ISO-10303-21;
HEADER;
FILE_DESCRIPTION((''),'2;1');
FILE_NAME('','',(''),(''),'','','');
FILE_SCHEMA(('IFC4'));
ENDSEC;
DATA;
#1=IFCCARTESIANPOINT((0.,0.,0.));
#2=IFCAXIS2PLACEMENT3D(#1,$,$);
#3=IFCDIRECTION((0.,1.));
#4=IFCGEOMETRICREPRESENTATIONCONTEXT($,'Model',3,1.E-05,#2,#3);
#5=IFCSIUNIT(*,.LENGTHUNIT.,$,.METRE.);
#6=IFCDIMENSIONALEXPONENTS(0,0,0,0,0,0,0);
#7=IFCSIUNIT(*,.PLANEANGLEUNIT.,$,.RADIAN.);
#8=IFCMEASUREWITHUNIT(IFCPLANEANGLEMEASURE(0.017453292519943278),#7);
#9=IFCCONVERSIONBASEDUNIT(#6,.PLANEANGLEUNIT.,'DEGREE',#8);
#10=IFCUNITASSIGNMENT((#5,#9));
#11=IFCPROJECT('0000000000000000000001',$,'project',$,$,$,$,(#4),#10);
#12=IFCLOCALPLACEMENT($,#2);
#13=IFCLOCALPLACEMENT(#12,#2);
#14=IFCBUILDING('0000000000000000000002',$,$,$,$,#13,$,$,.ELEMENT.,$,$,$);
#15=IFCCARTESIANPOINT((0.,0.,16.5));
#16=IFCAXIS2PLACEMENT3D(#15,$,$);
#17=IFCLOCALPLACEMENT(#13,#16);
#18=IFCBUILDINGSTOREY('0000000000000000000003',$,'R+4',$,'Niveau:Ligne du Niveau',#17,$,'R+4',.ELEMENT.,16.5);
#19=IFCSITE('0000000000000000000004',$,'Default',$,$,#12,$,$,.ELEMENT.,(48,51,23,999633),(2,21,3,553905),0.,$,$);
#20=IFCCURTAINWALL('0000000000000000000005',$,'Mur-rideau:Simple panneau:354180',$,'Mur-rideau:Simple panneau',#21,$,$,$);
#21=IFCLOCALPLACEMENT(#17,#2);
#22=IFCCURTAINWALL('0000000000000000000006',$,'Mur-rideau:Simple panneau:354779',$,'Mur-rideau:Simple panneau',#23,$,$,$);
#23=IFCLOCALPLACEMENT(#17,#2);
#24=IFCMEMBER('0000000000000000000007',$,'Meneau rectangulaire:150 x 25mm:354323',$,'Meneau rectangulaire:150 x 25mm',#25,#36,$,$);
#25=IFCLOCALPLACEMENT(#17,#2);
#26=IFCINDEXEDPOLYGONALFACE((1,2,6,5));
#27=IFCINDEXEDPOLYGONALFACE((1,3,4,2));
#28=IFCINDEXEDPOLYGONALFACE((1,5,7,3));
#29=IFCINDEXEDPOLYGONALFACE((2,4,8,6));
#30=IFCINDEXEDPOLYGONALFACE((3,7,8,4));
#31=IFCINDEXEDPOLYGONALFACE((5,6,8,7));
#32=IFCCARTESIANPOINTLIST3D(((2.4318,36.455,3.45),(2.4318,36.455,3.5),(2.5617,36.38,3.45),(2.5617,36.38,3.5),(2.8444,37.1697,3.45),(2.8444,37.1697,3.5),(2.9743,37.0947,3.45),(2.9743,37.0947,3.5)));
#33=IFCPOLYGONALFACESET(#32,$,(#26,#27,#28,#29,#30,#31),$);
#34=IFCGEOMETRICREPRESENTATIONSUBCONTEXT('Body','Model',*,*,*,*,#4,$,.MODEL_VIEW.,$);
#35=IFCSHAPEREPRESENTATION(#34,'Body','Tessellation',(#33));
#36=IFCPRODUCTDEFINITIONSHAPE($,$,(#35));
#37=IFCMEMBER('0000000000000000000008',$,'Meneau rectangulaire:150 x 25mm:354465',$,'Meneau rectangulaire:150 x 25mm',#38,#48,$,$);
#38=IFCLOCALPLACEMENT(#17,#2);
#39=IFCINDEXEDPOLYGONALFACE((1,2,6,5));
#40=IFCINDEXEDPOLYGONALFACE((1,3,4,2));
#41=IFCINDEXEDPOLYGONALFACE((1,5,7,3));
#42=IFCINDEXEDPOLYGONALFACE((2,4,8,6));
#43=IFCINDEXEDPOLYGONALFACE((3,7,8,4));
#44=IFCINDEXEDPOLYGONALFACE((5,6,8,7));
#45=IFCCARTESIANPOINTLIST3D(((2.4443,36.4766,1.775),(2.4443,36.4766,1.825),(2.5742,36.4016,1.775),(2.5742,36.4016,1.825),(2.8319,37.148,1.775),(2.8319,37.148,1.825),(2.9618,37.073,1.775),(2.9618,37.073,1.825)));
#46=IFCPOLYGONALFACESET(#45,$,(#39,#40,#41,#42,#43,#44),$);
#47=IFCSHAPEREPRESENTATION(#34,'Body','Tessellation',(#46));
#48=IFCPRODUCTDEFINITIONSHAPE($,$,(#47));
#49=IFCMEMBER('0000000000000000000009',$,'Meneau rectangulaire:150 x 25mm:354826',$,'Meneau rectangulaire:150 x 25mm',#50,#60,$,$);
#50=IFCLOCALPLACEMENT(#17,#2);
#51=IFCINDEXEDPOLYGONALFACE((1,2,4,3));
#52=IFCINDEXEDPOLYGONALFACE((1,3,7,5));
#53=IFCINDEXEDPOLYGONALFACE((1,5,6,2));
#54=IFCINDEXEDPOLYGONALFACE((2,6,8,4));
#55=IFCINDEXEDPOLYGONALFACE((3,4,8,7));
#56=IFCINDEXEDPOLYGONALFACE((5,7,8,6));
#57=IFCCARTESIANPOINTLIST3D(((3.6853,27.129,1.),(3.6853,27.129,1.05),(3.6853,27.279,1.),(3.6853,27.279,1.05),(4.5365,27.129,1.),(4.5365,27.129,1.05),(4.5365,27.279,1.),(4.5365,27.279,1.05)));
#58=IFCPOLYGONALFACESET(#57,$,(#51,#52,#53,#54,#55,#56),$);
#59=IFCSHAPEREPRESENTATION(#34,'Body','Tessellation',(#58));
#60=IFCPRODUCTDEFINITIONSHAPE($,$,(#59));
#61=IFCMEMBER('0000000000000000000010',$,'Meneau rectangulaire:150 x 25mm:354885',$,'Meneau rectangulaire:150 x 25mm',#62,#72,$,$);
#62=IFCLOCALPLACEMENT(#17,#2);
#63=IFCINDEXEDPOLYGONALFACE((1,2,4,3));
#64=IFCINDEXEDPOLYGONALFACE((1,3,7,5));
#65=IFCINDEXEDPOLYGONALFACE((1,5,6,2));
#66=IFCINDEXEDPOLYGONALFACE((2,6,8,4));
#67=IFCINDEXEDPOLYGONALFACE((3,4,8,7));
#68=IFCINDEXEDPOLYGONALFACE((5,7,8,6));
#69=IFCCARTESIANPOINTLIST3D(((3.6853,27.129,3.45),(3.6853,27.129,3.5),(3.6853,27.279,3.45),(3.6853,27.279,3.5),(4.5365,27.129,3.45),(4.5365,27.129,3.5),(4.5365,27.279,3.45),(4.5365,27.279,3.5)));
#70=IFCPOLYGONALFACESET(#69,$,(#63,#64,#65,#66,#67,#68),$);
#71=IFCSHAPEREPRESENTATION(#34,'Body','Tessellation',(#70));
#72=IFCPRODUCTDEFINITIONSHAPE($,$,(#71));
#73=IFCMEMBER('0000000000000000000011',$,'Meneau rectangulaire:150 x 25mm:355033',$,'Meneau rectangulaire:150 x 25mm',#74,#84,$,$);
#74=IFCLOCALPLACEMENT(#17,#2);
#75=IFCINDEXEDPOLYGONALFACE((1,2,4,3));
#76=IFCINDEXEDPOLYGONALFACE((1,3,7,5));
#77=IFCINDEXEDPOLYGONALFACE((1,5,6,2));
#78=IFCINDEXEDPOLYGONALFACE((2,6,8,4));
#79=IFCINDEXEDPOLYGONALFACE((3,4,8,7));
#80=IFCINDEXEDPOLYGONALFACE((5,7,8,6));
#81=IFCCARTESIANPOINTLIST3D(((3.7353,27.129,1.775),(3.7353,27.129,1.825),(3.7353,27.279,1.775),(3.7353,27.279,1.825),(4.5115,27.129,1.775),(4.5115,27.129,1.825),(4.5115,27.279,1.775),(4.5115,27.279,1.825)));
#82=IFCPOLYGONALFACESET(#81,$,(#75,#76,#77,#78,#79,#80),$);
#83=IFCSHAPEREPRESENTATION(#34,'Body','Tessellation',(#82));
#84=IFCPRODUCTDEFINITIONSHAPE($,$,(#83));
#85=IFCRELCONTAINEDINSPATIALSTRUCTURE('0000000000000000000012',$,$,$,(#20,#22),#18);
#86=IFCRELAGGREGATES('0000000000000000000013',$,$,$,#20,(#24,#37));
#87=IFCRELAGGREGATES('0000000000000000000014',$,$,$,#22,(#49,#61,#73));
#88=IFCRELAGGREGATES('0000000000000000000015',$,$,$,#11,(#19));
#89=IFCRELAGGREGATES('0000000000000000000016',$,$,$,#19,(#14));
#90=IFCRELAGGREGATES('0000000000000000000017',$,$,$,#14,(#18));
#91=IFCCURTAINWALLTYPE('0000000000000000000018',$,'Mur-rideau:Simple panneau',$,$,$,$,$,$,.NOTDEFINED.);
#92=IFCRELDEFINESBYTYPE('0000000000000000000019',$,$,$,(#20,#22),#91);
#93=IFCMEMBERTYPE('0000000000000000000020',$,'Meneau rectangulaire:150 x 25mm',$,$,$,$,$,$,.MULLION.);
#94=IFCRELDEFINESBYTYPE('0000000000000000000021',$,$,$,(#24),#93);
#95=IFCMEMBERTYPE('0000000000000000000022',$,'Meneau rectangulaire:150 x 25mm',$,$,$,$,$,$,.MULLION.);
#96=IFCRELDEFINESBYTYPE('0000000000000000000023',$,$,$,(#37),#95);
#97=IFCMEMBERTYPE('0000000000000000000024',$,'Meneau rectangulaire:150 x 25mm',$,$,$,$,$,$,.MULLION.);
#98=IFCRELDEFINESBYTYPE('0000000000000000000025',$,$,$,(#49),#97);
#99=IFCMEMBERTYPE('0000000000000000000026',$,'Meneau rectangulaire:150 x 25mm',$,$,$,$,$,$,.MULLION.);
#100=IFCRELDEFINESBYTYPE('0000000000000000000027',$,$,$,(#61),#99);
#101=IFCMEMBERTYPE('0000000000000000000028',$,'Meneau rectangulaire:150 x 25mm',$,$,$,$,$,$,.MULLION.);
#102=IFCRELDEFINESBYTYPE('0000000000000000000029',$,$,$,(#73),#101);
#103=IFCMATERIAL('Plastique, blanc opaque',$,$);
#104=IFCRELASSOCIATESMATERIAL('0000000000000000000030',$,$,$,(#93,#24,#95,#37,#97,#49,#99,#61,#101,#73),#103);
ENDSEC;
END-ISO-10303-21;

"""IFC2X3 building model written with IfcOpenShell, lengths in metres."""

from ifc_helpers import new_model, entity, si_unit, converted_unit, direction, frame, origin, origin_2d_with_axis, place, context, subcontext, project, spatial, rectangle, extrude, source, transform, mapped, material, type_object, type_shapes, element, aggregate, save


model = new_model("IFC2X3")

# Units and contexts
model_context = context("Model", 3, precision=1e-05, world=origin(), true_north=direction((0.0, 1.0)))
body_context = subcontext(model_context, "Body", "Model", "MODEL_VIEW")
ifc_project = project(units=[si_unit("LENGTHUNIT", "METRE"), converted_unit("PLANEANGLEUNIT", "DEGREE", entity("IfcPlaneAngleMeasure", 0.017453292519943278), si_unit("PLANEANGLEUNIT", "RADIAN"), dimensions=[0, 0, 0, 0, 0, 0, 0])], contexts=[model_context])

# Site, building, storey
site_placement = place(None, origin())
site = spatial("IfcSite", under=ifc_project, at=site_placement, Name="Default", CompositionType="ELEMENT", RefLatitude=(48, 51, 23, 999633), RefLongitude=(2, 21, 3, 553905), RefElevation=0.0)
building_placement = place(site_placement, origin())
building = spatial("IfcBuilding", under=site, at=building_placement, CompositionType="ELEMENT")
storey_placement = place(building_placement, frame((0.0, 0.0, 16.5)))
storey = spatial("IfcBuildingStorey", under=building, at=storey_placement, Name="R+4", ObjectType="Niveau:Ligne du Niveau", LongName="R+4", CompositionType="ELEMENT", Elevation=16.5)

# Curtain walls
curtain_wall_type = type_object("IfcCurtainWallType", Name="Mur-rideau:Simple panneau", PredefinedType="NOTDEFINED")
curtain_wall_1_placement = place(storey_placement, frame((0.0, 0.0, -16.5)))
curtain_wall_1 = element("IfcCurtainWall", 1, at=curtain_wall_1_placement, inside=storey, type_object=curtain_wall_type, Name="Mur-rideau:Simple panneau:354180", ObjectType="Mur-rideau:Simple panneau")
ifc_material_1 = material(Name="Plastique, blanc opaque")
curtain_wall_2_placement = place(storey_placement, frame((0.0, 0.0, -16.5)))
curtain_wall_2 = element("IfcCurtainWall", 2, at=curtain_wall_2_placement, inside=storey, type_object=curtain_wall_type, Name="Mur-rideau:Simple panneau:354779", ObjectType="Mur-rideau:Simple panneau")

# Members
member_type_1 = type_object("IfcMemberType", Name="Meneau rectangulaire:150 x 25mm", PredefinedType="MULLION", material=ifc_material_1)
shared_shape_1 = source(origin(), body_context, "Body", "SweptSolid", [
    extrude(rectangle(XDim=0.05, YDim=0.15, at=origin_2d_with_axis()), frame((-0.025, 0.0, -0.8253), z_axis=(0.0, 0.0, 1.0), x_axis=(-1.0, 0.0, 0.0)), (0.0, 0.0, 1.0), 0.8253),
])
type_shapes(member_type_1, [shared_shape_1])
member_1_placement = place(curtain_wall_1_placement, frame((2.4968, 36.4175, 20.0), z_axis=(-0.5, -0.866025, 0.0), x_axis=(0.0, 0.0, 1.0)))
member_1 = element("IfcMember", 3, at=member_1_placement, type_object=member_type_1, material=ifc_material_1, Name="Meneau rectangulaire:150 x 25mm:354323", ObjectType="Meneau rectangulaire:150 x 25mm", context=body_context, shape_type="MappedRepresentation", body=[
    mapped(shared_shape_1, transform((0.0, 0.0, 0.0), scale=1.0)),
])
member_type_2 = type_object("IfcMemberType", Name="Meneau rectangulaire:150 x 25mm", PredefinedType="MULLION", material=ifc_material_1)
shared_shape_2 = source(origin(), body_context, "Body", "SweptSolid", [
    extrude(rectangle(XDim=0.05, YDim=0.15, at=origin_2d_with_axis()), frame((0.0, 0.0, -0.7753), z_axis=(0.0, 0.0, 1.0), x_axis=(-1.0, 0.0, 0.0)), (0.0, 0.0, 1.0), 0.7753),
])
type_shapes(member_type_2, [shared_shape_2])
member_2_placement = place(curtain_wall_1_placement, frame((2.5093, 36.4391, 18.3), z_axis=(-0.5, -0.866025, 0.0), x_axis=(0.0, 0.0, 1.0)))
member_2 = element("IfcMember", 4, at=member_2_placement, type_object=member_type_2, material=ifc_material_1, Name="Meneau rectangulaire:150 x 25mm:354465", ObjectType="Meneau rectangulaire:150 x 25mm", context=body_context, shape_type="MappedRepresentation", body=[
    mapped(shared_shape_2, transform((0.0, 0.0, 0.0), scale=1.0)),
])
member_type_3 = type_object("IfcMemberType", Name="Meneau rectangulaire:150 x 25mm", PredefinedType="MULLION", material=ifc_material_1)
shared_shape_3 = source(origin(), body_context, "Body", "SweptSolid", [
    extrude(rectangle(XDim=0.05, YDim=0.15, at=origin_2d_with_axis()), frame((-0.025, 0.0, -0.8511), z_axis=(0.0, 0.0, 1.0), x_axis=(-1.0, 0.0, 0.0)), (0.0, 0.0, 1.0), 0.8511),
])
type_shapes(member_type_3, [shared_shape_3])
member_3_placement = place(curtain_wall_2_placement, frame((3.6853, 27.204, 17.5), z_axis=(-1.0, 0.0, 0.0), x_axis=(0.0, 0.0, -1.0)))
member_3 = element("IfcMember", 5, at=member_3_placement, type_object=member_type_3, material=ifc_material_1, Name="Meneau rectangulaire:150 x 25mm:354826", ObjectType="Meneau rectangulaire:150 x 25mm", context=body_context, shape_type="MappedRepresentation", body=[
    mapped(shared_shape_3, transform((0.0, 0.0, 0.0), scale=1.0)),
])
member_type_4 = type_object("IfcMemberType", Name="Meneau rectangulaire:150 x 25mm", PredefinedType="MULLION", material=ifc_material_1)
shared_shape_4 = source(origin(), body_context, "Body", "SweptSolid", [
    extrude(rectangle(XDim=0.05, YDim=0.15, at=origin_2d_with_axis()), frame((-0.025, 0.0, -0.8511), z_axis=(0.0, 0.0, 1.0), x_axis=(-1.0, 0.0, 0.0)), (0.0, 0.0, 1.0), 0.8511),
])
type_shapes(member_type_4, [shared_shape_4])
member_4_placement = place(curtain_wall_2_placement, frame((4.5365, 27.204, 20.0), z_axis=(1.0, 0.0, 0.0), x_axis=(0.0, 0.0, 1.0)))
member_4 = element("IfcMember", 6, at=member_4_placement, type_object=member_type_4, material=ifc_material_1, Name="Meneau rectangulaire:150 x 25mm:354885", ObjectType="Meneau rectangulaire:150 x 25mm", context=body_context, shape_type="MappedRepresentation", body=[
    mapped(shared_shape_4, transform((0.0, 0.0, 0.0), scale=1.0)),
])
member_type_5 = type_object("IfcMemberType", Name="Meneau rectangulaire:150 x 25mm", PredefinedType="MULLION", material=ifc_material_1)
shared_shape_5 = source(origin(), body_context, "Body", "SweptSolid", [
    extrude(rectangle(XDim=0.05, YDim=0.15, at=origin_2d_with_axis()), frame((0.0, 0.0, -0.7761), z_axis=(0.0, 0.0, 1.0), x_axis=(-1.0, 0.0, 0.0)), (0.0, 0.0, 1.0), 0.7761),
])
type_shapes(member_type_5, [shared_shape_5])
member_5_placement = place(curtain_wall_2_placement, frame((4.5115, 27.204, 18.3), z_axis=(1.0, 0.0, 0.0), x_axis=(0.0, 0.0, 1.0)))
member_5 = element("IfcMember", 7, at=member_5_placement, type_object=member_type_5, material=ifc_material_1, Name="Meneau rectangulaire:150 x 25mm:355033", ObjectType="Meneau rectangulaire:150 x 25mm", context=body_context, shape_type="MappedRepresentation", body=[
    mapped(shared_shape_5, transform((0.0, 0.0, 0.0), scale=1.0)),
])

aggregate(curtain_wall_1, [member_1, member_2])
aggregate(curtain_wall_2, [member_3, member_4, member_5])

save(model, "model.ifc")
